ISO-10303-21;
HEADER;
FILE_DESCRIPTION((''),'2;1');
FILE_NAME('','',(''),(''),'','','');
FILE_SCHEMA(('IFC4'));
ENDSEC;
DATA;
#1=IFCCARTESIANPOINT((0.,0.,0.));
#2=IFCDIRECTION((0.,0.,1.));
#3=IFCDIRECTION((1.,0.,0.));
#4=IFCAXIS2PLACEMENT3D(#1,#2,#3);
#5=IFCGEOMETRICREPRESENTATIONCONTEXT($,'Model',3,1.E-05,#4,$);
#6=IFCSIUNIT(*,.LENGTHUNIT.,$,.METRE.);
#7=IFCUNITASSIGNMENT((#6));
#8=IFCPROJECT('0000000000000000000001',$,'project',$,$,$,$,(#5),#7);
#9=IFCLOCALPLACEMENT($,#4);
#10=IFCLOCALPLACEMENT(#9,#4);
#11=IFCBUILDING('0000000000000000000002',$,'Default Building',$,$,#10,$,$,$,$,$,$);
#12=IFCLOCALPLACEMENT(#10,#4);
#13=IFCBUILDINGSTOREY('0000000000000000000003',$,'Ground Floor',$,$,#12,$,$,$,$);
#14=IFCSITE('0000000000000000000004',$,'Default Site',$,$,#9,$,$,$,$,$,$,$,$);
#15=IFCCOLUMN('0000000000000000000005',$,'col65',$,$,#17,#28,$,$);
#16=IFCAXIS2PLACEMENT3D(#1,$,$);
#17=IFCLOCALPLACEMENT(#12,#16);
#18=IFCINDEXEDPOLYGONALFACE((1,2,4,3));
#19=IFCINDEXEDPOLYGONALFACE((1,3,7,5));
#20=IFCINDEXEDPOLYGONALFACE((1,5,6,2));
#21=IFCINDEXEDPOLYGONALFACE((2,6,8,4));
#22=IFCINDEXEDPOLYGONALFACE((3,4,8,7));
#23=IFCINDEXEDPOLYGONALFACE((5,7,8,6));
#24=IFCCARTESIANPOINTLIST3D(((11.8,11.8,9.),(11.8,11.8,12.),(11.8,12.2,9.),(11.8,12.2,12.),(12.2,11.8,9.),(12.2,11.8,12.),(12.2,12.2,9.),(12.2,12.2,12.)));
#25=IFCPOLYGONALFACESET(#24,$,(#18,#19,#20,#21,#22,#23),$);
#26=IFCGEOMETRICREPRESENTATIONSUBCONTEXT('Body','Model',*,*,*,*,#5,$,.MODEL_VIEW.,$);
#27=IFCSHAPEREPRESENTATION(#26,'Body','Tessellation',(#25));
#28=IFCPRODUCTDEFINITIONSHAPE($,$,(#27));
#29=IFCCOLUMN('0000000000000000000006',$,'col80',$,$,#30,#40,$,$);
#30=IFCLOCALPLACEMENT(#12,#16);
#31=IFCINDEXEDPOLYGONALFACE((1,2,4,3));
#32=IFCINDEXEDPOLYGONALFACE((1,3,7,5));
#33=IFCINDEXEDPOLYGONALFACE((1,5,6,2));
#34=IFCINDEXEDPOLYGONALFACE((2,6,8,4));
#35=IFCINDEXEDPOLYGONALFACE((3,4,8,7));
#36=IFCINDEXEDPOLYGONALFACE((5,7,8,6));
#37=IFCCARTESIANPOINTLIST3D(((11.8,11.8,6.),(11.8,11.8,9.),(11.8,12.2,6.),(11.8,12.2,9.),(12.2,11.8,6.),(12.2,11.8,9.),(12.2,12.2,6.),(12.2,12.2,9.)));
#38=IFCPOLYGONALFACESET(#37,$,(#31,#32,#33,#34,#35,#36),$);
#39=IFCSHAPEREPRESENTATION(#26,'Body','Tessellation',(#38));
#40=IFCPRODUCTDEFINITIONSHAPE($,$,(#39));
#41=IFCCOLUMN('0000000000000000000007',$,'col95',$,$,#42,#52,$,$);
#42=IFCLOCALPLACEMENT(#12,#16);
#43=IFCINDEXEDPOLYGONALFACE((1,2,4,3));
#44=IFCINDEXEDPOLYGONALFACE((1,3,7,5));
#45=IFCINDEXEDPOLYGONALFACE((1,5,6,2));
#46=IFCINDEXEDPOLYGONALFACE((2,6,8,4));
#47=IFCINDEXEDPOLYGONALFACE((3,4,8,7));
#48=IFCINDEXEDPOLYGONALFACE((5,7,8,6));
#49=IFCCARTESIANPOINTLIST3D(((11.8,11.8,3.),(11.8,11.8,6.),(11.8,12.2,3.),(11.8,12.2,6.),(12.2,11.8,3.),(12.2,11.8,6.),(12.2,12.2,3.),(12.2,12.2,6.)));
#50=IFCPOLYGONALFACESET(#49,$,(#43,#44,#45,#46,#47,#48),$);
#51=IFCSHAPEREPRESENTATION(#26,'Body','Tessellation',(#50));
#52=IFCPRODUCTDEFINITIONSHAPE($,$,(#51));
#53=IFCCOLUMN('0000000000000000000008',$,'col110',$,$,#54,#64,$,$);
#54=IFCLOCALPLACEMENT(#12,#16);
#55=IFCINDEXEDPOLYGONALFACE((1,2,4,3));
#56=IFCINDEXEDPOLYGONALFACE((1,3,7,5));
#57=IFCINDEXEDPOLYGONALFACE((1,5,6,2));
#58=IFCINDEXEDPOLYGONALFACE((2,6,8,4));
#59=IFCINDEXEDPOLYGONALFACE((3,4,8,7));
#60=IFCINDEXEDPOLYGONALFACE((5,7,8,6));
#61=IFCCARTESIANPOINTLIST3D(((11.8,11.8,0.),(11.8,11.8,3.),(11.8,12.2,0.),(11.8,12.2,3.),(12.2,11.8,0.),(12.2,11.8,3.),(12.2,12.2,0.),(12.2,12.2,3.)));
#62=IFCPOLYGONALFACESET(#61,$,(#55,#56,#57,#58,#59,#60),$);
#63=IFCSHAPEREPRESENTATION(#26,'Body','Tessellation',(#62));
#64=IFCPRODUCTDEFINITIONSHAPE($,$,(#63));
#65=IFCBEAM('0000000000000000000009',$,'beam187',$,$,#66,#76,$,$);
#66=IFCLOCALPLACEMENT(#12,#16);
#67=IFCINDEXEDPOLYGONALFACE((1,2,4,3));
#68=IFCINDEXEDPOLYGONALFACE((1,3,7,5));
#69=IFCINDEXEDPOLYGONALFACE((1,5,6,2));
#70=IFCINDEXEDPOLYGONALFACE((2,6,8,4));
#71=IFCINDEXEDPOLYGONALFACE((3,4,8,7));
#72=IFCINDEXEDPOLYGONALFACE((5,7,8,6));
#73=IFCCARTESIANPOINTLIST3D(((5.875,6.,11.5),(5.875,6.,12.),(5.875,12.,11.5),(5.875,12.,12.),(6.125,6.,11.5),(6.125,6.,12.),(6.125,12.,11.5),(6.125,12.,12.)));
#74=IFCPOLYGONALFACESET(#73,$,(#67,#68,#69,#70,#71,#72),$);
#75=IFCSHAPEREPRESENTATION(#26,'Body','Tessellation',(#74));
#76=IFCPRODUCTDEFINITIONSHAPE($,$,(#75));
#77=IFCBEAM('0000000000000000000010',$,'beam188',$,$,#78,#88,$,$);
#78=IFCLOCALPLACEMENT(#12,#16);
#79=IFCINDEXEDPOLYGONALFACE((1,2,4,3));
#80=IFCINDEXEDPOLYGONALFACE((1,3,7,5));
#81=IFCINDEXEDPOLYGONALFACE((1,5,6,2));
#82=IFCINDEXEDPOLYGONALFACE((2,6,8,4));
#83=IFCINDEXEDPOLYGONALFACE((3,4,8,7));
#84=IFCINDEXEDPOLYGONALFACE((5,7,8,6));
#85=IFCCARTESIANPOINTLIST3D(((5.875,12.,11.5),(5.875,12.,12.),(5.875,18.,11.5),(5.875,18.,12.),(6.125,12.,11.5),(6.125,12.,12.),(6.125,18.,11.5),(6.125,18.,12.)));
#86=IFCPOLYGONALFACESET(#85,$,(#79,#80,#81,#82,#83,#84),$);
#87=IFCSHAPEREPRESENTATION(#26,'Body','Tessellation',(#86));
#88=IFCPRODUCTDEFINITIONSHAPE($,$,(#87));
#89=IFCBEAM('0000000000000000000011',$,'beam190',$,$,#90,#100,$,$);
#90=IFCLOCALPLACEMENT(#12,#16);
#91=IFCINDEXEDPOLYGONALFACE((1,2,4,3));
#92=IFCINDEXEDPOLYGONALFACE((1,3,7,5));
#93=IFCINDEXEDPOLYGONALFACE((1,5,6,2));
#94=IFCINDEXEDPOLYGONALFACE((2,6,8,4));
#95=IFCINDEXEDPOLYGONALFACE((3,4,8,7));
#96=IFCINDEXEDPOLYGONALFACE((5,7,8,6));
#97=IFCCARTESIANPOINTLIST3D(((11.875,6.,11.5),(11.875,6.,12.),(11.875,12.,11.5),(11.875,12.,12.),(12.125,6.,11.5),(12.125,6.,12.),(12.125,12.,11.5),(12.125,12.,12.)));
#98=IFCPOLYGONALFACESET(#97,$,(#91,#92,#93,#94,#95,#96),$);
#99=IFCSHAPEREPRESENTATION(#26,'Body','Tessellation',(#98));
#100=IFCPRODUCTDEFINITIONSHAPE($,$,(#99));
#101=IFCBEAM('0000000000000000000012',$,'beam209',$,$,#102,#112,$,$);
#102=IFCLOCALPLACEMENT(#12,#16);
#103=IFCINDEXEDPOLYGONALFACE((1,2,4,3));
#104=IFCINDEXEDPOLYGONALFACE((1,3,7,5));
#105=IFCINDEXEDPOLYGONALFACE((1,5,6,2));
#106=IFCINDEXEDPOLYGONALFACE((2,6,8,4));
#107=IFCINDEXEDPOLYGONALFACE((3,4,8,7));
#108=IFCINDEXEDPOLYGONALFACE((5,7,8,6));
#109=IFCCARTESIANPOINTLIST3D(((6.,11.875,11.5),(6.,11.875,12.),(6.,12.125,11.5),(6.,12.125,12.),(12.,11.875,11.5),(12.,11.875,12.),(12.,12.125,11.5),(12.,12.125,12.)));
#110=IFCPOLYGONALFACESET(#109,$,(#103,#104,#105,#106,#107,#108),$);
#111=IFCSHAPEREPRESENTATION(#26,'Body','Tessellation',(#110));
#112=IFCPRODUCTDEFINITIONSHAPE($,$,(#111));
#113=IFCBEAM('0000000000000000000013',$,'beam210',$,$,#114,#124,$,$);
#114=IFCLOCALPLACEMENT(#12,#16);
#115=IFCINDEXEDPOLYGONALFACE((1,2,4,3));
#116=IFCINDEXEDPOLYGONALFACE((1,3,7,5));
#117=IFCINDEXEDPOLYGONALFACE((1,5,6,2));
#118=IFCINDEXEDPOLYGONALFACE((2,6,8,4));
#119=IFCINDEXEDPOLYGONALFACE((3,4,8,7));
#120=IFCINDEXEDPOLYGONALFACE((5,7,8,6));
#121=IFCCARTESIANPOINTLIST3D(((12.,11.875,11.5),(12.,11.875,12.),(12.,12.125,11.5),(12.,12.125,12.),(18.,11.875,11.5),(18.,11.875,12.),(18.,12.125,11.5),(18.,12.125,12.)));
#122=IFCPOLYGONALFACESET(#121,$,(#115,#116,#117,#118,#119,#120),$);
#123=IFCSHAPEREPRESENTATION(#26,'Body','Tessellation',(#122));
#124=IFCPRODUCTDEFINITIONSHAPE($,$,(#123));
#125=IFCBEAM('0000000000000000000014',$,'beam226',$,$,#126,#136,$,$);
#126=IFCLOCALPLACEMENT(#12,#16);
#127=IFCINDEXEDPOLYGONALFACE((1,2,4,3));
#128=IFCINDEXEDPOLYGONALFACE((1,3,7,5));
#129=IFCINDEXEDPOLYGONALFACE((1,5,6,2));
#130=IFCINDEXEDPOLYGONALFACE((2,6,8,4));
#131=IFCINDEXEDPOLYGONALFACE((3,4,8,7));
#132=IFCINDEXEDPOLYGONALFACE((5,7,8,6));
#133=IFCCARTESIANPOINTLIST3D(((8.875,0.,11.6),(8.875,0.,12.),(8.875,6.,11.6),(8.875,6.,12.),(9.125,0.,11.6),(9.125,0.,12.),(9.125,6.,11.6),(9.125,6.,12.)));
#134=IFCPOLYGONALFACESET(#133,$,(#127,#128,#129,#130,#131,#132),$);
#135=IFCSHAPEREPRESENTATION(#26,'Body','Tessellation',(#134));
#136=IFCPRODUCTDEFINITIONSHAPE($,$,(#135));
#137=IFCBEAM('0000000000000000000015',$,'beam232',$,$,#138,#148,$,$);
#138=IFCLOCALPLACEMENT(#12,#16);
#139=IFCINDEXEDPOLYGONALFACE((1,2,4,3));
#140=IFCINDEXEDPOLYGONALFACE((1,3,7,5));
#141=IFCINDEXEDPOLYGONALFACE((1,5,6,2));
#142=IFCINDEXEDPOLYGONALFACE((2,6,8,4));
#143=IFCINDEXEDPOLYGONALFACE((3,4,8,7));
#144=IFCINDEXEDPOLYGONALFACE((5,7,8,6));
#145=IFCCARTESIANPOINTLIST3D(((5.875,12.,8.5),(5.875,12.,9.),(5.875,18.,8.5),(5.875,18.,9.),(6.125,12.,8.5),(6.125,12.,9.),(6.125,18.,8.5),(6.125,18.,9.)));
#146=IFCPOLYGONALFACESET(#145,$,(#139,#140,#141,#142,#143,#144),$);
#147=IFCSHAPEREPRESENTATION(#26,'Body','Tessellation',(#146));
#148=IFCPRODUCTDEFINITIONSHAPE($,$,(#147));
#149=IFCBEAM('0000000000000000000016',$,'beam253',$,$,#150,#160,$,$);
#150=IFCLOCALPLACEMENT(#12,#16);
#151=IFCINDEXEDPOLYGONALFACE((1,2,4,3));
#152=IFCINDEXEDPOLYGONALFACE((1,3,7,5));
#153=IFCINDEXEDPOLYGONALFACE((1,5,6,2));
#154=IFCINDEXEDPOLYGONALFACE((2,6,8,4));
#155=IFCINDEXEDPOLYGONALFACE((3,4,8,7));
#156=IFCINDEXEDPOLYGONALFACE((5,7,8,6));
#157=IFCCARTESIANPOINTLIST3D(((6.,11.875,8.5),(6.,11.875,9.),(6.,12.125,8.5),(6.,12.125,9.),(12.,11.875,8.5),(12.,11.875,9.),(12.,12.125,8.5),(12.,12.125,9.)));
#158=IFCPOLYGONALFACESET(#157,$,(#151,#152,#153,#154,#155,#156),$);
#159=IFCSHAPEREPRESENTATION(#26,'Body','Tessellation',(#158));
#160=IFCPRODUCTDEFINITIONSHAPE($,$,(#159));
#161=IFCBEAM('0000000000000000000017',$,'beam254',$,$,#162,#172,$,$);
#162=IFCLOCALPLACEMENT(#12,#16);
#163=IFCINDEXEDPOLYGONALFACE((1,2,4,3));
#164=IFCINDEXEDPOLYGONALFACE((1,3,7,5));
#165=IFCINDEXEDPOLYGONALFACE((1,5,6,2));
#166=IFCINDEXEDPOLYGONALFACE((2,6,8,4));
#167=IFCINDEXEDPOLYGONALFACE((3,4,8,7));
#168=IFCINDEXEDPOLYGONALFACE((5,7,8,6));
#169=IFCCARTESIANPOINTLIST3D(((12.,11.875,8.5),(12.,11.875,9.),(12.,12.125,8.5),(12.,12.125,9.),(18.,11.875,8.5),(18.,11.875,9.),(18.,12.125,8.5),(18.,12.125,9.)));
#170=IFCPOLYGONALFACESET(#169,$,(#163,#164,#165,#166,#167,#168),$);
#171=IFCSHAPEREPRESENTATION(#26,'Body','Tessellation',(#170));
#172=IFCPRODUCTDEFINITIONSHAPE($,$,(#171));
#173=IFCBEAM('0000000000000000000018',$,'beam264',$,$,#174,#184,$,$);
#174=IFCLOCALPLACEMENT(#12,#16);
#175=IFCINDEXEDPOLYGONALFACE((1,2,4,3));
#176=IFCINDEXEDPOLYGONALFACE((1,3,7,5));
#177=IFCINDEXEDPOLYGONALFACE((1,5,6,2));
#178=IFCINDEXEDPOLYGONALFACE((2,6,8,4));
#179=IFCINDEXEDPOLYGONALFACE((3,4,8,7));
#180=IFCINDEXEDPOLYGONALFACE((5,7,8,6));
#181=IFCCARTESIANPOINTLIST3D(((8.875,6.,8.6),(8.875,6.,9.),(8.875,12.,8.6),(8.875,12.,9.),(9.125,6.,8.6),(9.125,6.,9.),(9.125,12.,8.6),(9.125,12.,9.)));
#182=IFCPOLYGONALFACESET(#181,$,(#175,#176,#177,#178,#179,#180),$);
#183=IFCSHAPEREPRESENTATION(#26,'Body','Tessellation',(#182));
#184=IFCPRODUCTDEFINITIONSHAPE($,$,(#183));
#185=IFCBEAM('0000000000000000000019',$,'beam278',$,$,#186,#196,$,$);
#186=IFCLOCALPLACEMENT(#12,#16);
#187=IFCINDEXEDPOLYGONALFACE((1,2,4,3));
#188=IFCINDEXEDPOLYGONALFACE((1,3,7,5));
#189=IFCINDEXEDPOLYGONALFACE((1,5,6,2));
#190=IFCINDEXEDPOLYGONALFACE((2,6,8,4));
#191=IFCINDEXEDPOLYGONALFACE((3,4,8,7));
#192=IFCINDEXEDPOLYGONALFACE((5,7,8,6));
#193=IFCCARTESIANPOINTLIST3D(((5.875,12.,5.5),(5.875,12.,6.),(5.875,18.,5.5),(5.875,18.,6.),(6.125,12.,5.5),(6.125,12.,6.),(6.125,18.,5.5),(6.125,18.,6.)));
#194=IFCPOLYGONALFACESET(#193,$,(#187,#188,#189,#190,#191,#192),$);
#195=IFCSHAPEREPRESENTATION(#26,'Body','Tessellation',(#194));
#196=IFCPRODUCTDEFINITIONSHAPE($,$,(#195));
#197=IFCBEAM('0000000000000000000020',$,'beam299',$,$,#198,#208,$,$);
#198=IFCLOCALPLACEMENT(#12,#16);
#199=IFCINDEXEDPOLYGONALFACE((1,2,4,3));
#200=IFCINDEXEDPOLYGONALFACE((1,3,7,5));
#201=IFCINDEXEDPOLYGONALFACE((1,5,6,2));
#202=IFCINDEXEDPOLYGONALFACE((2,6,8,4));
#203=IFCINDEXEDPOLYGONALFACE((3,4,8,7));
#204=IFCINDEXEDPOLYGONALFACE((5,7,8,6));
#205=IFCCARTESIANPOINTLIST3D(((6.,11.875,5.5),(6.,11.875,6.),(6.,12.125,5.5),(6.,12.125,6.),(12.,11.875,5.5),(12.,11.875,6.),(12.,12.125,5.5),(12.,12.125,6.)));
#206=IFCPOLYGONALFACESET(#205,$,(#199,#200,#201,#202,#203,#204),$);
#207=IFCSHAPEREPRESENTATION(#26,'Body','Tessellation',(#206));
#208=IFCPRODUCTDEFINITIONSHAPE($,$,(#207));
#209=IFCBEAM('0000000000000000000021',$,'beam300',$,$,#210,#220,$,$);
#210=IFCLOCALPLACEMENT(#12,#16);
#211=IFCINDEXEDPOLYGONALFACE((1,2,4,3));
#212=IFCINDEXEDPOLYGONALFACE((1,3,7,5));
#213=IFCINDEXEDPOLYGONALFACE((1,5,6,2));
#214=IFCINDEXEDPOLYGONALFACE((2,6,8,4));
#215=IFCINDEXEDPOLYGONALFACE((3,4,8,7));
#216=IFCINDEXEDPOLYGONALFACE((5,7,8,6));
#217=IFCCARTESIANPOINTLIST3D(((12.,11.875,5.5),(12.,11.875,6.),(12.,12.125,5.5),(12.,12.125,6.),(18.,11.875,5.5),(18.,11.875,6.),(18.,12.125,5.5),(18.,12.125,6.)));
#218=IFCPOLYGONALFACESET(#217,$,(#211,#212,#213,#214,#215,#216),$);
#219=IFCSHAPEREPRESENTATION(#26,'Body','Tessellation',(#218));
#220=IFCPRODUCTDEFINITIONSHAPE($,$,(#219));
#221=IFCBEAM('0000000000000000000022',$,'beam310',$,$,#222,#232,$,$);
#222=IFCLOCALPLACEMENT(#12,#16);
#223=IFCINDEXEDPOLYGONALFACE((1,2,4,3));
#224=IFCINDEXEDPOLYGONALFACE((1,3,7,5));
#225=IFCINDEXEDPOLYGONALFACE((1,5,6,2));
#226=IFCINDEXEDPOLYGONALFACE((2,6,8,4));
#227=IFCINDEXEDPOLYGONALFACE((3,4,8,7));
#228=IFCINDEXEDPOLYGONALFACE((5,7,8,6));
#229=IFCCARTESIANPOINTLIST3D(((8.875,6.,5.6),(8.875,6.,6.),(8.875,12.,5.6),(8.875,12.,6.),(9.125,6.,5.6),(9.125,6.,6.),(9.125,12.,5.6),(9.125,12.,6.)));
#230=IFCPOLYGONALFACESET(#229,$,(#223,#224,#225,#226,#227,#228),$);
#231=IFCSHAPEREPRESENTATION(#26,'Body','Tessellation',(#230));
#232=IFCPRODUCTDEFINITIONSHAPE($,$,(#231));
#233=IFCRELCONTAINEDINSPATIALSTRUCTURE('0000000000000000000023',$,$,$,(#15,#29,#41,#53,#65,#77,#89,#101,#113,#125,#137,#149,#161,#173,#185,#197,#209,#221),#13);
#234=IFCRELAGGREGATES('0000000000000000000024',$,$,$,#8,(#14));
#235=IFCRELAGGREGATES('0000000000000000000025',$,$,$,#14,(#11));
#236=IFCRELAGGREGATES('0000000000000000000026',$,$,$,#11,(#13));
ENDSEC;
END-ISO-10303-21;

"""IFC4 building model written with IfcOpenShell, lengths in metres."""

from ifc_helpers import new_model, si_unit, frame, origin_with_axes, place, context, subcontext, project, spatial, indexed_curve, outline, extrude, element, save


model = new_model("IFC4")

# Units and contexts
model_context = context("Model", 3, precision=1e-05, world=origin_with_axes())
body_context = subcontext(model_context, "Body", "Model", "MODEL_VIEW")
ifc_project = project(units=[si_unit("LENGTHUNIT", "METRE")], contexts=[model_context])

# Site, building, storey
site_placement = place(None, origin_with_axes())
site = spatial("IfcSite", under=ifc_project, at=site_placement, Name="Default Site")
building_placement = place(site_placement, origin_with_axes())
building = spatial("IfcBuilding", under=site, at=building_placement, Name="Default Building")
storey_placement = place(building_placement, origin_with_axes())
storey = spatial("IfcBuildingStorey", under=building, at=storey_placement, Name="Ground Floor")

# Columns
for number, where, z_axis, x_axis, name in (
    (1, (11.8, 11.8, 9.0), (0.0, 0.0, 1.0), (1.0, 0.0, 0.0), "col65"),
    (2, (11.8, 11.8, 6.0), (0.0, 0.0, 1.0), (1.0, 0.0, 0.0), "col80"),
    (3, (11.8, 11.8, 3.0), (0.0, 0.0, 1.0), (1.0, 0.0, 0.0), "col95"),
    (4, (11.8, 11.8, 0.0), (0.0, 0.0, 1.0), (1.0, 0.0, 0.0), "col110"),
):
    element("IfcColumn", number, at=place(storey_placement, frame(where, z_axis=z_axis, x_axis=x_axis)), inside=storey, Name=name, context=body_context, shape_type="SweptSolid", body=[
        extrude(outline(indexed_curve([(0.0, 0.0), (0.0, 0.4), (0.4, 0.4), (0.4, 0.0), (0.0, 0.0)], self_intersect=False)), origin_with_axes(), (0.0, 0.0, 1.0), 3.0),
    ])

# Beams
for number, where, z_axis, x_axis, name in (
    (5, (6.125, 6.0, 11.5), (0.0, 0.0, 1.0), (0.0, 1.0, 0.0), "beam187"),
    (6, (6.125, 12.0, 11.5), (0.0, 0.0, 1.0), (0.0, 1.0, 0.0), "beam188"),
    (7, (12.125, 6.0, 11.5), (0.0, 0.0, 1.0), (0.0, 1.0, 0.0), "beam190"),
    (8, (6.0, 11.875, 11.5), (0.0, 0.0, 1.0), (1.0, 0.0, 0.0), "beam209"),
    (9, (12.0, 11.875, 11.5), (0.0, 0.0, 1.0), (1.0, 0.0, 0.0), "beam210"),
):
    element("IfcBeam", number, at=place(storey_placement, frame(where, z_axis=z_axis, x_axis=x_axis)), inside=storey, Name=name, context=body_context, shape_type="SweptSolid", body=[
        extrude(outline(indexed_curve([(0.0, 0.0), (0.0, 0.25), (6.0, 0.25), (6.0, 0.0), (0.0, 0.0)], self_intersect=False)), origin_with_axes(), (0.0, 0.0, 1.0), 0.5),
    ])
beam_1_placement = place(storey_placement, frame((8.875, 6.0, 11.6), z_axis=(0.0, 0.0, 1.0), x_axis=(0.0, -1.0, 0.0)))
element("IfcBeam", 10, at=beam_1_placement, inside=storey, Name="beam226", context=body_context, shape_type="SweptSolid", body=[
    extrude(outline(indexed_curve([(0.0, 0.0), (0.0, 0.25), (6.0, 0.25), (6.0, 0.0), (0.0, 0.0)], self_intersect=False)), origin_with_axes(), (0.0, 0.0, 1.0), 0.4),
])
for number, where, z_axis, x_axis, name in (
    (11, (6.125, 12.0, 8.5), (0.0, 0.0, 1.0), (0.0, 1.0, 0.0), "beam232"),
    (12, (6.0, 11.875, 8.5), (0.0, 0.0, 1.0), (1.0, 0.0, 0.0), "beam253"),
    (13, (12.0, 11.875, 8.5), (0.0, 0.0, 1.0), (1.0, 0.0, 0.0), "beam254"),
):
    element("IfcBeam", number, at=place(storey_placement, frame(where, z_axis=z_axis, x_axis=x_axis)), inside=storey, Name=name, context=body_context, shape_type="SweptSolid", body=[
        extrude(outline(indexed_curve([(0.0, 0.0), (0.0, 0.25), (6.0, 0.25), (6.0, 0.0), (0.0, 0.0)], self_intersect=False)), origin_with_axes(), (0.0, 0.0, 1.0), 0.5),
    ])
beam_2_placement = place(storey_placement, frame((8.875, 12.0, 8.6), z_axis=(0.0, 0.0, 1.0), x_axis=(0.0, -1.0, 0.0)))
element("IfcBeam", 14, at=beam_2_placement, inside=storey, Name="beam264", context=body_context, shape_type="SweptSolid", body=[
    extrude(outline(indexed_curve([(0.0, 0.0), (0.0, 0.25), (6.0, 0.25), (6.0, 0.0), (0.0, 0.0)], self_intersect=False)), origin_with_axes(), (0.0, 0.0, 1.0), 0.4),
])
for number, where, z_axis, x_axis, name in (
    (15, (6.125, 12.0, 5.5), (0.0, 0.0, 1.0), (0.0, 1.0, 0.0), "beam278"),
    (16, (6.0, 11.875, 5.5), (0.0, 0.0, 1.0), (1.0, 0.0, 0.0), "beam299"),
    (17, (12.0, 11.875, 5.5), (0.0, 0.0, 1.0), (1.0, 0.0, 0.0), "beam300"),
):
    element("IfcBeam", number, at=place(storey_placement, frame(where, z_axis=z_axis, x_axis=x_axis)), inside=storey, Name=name, context=body_context, shape_type="SweptSolid", body=[
        extrude(outline(indexed_curve([(0.0, 0.0), (0.0, 0.25), (6.0, 0.25), (6.0, 0.0), (0.0, 0.0)], self_intersect=False)), origin_with_axes(), (0.0, 0.0, 1.0), 0.5),
    ])
beam_3_placement = place(storey_placement, frame((8.875, 12.0, 5.6), z_axis=(0.0, 0.0, 1.0), x_axis=(0.0, -1.0, 0.0)))
element("IfcBeam", 18, at=beam_3_placement, inside=storey, Name="beam310", context=body_context, shape_type="SweptSolid", body=[
    extrude(outline(indexed_curve([(0.0, 0.0), (0.0, 0.25), (6.0, 0.25), (6.0, 0.0), (0.0, 0.0)], self_intersect=False)), origin_with_axes(), (0.0, 0.0, 1.0), 0.4),
])

save(model, "model.ifc")
